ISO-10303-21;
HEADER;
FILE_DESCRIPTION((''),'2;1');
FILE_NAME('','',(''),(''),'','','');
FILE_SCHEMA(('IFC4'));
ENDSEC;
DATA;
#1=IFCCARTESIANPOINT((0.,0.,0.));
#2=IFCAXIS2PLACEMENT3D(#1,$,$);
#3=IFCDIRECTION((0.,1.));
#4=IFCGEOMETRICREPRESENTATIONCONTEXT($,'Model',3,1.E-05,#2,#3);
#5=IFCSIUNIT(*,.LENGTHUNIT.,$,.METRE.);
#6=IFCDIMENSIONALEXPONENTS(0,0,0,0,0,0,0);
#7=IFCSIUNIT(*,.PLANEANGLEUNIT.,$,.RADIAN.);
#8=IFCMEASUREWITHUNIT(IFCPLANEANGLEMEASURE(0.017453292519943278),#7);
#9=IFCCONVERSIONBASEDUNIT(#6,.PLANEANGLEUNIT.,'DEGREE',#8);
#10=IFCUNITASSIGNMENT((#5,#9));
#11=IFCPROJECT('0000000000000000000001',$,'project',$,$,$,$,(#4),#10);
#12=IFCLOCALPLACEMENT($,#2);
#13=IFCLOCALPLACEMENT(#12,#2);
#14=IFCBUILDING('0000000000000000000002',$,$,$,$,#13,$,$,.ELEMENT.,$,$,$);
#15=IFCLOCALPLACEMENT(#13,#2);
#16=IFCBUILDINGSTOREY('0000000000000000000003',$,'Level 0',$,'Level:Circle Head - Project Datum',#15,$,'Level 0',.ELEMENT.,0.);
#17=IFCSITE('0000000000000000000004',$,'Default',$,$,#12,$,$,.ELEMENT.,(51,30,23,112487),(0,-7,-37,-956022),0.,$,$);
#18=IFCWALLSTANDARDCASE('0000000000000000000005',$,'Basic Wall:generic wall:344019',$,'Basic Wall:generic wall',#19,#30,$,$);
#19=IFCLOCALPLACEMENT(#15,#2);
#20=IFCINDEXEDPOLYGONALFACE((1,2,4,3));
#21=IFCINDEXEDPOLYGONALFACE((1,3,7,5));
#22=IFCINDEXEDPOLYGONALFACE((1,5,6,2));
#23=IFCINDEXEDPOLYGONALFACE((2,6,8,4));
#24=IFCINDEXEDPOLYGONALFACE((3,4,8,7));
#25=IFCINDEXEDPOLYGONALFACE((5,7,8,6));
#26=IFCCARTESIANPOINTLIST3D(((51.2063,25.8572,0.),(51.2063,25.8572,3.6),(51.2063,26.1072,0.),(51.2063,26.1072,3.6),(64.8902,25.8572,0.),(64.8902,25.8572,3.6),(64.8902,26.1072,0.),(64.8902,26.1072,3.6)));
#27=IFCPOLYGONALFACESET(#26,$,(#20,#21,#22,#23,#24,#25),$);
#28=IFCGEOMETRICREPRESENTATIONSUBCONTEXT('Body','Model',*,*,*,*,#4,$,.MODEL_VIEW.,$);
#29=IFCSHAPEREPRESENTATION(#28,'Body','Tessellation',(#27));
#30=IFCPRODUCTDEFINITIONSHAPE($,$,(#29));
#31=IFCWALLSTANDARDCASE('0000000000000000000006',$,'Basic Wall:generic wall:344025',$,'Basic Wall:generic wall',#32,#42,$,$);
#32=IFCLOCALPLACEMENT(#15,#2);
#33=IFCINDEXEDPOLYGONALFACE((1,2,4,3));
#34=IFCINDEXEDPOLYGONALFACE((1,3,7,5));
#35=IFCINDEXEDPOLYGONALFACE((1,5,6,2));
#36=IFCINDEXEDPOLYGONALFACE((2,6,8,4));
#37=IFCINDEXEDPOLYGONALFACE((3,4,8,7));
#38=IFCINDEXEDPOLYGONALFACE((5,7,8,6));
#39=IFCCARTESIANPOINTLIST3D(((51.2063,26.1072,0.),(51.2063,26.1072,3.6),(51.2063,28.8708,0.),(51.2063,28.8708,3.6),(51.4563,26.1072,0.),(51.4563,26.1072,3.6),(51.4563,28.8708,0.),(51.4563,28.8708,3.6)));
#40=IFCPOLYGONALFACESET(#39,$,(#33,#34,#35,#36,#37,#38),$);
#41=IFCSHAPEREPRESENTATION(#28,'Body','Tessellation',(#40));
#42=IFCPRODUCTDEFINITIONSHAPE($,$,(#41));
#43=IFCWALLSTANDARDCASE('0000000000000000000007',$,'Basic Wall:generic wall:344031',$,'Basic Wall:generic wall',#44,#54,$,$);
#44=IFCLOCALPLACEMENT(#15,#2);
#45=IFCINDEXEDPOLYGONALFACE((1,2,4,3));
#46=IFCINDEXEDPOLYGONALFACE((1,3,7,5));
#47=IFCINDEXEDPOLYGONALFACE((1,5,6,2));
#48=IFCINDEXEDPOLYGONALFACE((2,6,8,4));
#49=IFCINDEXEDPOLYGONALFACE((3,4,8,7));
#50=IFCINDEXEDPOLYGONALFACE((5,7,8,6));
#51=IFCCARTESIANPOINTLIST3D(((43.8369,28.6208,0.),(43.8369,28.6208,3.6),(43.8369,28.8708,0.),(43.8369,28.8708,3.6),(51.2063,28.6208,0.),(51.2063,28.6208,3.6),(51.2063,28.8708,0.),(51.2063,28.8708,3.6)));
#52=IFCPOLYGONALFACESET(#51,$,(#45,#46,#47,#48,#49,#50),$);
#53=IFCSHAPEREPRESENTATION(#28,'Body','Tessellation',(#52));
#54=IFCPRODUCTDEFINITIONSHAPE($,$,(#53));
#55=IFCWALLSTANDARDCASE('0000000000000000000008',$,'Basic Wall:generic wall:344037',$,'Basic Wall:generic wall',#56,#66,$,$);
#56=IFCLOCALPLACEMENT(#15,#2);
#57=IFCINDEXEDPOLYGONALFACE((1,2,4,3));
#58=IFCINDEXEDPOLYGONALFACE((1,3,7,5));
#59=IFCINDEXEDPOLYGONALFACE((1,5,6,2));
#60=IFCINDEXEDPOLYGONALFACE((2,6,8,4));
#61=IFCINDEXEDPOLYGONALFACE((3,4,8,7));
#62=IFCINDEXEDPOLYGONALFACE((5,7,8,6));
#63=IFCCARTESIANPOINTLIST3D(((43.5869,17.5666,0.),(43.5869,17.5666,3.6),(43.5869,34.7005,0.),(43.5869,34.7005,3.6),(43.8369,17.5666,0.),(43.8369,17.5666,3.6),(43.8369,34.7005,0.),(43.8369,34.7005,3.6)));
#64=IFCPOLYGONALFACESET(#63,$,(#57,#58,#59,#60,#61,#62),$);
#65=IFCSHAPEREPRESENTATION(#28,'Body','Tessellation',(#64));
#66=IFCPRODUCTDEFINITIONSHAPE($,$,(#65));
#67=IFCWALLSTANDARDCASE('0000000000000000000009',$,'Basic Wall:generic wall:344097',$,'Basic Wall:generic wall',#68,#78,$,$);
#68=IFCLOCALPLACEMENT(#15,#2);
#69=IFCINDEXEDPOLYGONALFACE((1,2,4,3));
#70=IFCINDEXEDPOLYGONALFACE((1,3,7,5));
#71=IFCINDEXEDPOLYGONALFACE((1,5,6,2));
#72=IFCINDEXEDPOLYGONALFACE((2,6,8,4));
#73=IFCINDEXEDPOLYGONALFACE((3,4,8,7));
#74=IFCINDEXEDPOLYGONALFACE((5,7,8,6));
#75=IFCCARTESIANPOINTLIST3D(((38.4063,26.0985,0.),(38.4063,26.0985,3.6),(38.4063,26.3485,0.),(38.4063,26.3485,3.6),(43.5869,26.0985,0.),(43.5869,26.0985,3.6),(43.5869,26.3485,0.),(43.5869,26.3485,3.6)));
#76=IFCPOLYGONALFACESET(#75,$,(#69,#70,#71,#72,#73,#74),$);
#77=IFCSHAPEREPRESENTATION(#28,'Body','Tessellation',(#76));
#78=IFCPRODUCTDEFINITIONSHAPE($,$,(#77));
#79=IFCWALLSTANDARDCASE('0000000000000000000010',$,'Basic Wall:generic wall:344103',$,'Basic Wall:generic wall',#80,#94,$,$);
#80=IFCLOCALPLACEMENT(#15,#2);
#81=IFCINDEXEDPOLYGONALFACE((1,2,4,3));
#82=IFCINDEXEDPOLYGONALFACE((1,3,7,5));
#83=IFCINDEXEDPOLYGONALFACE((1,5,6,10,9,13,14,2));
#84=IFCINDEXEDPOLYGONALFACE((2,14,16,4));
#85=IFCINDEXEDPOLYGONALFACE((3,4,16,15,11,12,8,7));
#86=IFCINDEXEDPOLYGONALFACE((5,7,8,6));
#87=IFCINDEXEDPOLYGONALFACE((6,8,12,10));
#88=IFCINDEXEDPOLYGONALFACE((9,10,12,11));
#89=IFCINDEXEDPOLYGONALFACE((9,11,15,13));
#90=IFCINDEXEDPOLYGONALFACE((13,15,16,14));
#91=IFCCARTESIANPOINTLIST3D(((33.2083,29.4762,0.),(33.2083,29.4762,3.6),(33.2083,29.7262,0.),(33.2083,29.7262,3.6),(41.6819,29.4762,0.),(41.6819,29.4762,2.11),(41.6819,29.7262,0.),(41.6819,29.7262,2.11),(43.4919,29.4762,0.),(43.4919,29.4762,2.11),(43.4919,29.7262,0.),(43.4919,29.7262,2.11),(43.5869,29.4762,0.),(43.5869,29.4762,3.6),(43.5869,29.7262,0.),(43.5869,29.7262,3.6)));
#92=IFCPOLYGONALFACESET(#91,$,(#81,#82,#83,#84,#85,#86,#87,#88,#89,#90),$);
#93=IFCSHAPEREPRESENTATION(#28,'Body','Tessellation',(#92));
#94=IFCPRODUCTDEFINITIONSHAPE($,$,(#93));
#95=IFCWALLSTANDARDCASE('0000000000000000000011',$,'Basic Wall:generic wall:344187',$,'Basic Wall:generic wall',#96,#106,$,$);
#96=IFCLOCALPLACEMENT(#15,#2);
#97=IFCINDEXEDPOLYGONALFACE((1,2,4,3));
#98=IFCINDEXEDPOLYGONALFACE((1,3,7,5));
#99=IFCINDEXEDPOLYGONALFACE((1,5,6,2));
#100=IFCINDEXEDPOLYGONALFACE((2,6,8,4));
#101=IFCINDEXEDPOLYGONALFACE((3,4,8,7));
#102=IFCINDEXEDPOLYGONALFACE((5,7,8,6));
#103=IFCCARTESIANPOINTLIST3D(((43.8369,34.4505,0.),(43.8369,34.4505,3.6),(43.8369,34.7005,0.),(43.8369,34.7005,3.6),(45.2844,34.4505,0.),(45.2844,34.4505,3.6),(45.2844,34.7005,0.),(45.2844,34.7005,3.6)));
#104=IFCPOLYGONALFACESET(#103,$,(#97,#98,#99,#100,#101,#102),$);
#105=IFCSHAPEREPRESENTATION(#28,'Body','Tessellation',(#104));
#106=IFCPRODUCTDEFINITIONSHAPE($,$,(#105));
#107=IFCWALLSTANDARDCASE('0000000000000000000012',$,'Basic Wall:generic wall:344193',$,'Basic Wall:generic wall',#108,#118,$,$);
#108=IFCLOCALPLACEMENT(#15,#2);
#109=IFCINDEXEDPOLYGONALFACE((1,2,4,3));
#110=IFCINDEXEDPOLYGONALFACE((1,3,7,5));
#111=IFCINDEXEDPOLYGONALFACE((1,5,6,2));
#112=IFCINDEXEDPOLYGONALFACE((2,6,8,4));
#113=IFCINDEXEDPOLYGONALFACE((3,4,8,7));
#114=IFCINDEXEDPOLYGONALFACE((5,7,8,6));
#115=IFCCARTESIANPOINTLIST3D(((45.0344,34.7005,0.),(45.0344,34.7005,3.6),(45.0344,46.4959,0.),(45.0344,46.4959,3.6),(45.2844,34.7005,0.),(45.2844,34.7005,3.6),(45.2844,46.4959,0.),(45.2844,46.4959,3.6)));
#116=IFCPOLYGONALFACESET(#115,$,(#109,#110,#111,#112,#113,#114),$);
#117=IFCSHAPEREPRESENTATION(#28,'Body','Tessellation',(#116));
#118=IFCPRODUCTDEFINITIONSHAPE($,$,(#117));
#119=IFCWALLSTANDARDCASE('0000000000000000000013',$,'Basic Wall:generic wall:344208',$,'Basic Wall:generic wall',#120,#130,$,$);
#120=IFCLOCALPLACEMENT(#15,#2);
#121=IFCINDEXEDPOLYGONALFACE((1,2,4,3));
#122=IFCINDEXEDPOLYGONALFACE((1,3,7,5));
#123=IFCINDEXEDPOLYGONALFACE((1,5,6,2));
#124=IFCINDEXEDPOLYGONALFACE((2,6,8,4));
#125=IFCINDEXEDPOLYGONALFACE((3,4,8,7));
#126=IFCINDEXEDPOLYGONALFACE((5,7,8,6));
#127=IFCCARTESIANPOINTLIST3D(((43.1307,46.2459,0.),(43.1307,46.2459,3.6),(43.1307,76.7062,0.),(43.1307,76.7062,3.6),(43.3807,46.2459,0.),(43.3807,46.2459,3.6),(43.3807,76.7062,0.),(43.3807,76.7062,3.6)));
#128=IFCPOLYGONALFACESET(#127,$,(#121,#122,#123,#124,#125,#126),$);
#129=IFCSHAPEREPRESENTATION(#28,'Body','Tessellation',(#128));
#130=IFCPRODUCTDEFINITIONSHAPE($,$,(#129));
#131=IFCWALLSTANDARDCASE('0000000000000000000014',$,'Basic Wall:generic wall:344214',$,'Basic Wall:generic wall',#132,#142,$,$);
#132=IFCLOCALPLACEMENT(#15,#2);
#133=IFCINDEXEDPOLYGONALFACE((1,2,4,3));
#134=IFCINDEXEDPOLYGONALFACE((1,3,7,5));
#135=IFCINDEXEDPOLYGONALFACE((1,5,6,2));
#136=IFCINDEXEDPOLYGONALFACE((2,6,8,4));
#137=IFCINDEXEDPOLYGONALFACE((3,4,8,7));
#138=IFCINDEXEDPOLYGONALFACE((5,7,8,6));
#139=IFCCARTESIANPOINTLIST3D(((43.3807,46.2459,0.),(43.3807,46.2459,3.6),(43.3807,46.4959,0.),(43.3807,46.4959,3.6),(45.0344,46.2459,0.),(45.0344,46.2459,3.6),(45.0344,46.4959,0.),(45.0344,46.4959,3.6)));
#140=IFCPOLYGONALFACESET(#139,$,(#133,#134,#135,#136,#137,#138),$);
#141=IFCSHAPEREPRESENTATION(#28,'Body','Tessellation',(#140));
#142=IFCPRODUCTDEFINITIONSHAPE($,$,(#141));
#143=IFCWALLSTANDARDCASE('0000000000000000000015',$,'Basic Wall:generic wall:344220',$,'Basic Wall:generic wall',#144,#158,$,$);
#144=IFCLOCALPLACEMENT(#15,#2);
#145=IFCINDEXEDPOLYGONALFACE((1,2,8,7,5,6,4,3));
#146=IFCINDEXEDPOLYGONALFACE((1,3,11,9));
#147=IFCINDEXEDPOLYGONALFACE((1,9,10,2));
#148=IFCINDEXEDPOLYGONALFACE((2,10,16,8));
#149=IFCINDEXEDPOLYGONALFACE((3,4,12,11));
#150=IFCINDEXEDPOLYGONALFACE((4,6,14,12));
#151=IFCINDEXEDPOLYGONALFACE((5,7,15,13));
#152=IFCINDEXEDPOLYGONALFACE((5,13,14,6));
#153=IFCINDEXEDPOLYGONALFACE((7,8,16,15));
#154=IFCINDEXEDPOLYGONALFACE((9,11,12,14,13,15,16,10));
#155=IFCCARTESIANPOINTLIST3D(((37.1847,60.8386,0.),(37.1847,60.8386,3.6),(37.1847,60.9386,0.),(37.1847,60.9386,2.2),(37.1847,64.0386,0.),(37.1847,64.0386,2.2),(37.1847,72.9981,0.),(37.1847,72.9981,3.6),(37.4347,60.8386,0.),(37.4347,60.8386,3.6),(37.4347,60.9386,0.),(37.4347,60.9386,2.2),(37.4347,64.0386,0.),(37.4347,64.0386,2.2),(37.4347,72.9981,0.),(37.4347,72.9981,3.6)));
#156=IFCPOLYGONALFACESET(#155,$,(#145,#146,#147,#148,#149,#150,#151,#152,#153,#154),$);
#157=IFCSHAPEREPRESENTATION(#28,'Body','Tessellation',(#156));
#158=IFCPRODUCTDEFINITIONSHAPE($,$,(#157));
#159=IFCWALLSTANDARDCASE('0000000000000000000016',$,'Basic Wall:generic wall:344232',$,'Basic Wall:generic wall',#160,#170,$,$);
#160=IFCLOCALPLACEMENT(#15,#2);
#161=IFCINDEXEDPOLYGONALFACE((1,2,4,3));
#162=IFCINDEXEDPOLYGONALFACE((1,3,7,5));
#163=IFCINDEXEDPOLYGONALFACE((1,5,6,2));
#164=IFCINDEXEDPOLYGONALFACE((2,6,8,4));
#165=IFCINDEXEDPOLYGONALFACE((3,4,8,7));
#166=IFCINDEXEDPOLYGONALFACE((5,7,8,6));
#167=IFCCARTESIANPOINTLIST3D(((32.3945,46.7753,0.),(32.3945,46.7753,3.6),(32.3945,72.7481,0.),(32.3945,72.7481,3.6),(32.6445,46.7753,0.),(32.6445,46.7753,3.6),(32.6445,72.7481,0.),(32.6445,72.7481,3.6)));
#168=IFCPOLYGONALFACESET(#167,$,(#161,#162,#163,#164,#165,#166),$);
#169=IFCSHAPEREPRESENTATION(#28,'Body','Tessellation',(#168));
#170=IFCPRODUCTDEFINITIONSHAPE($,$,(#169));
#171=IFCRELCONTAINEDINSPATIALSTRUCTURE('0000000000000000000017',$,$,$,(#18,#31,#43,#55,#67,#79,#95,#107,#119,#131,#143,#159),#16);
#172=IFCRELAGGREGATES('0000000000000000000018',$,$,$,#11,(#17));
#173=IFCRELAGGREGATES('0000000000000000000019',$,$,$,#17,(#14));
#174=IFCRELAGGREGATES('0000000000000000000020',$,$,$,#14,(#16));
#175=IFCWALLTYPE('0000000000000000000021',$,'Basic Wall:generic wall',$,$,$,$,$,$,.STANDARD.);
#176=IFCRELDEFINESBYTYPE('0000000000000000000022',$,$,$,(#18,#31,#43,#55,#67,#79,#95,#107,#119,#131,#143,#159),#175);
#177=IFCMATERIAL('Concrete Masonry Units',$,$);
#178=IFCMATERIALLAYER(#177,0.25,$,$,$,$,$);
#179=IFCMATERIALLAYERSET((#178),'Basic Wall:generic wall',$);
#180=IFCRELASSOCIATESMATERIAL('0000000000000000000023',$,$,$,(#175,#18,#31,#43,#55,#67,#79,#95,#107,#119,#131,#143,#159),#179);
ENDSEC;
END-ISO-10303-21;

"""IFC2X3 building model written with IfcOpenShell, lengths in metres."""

from ifc_helpers import new_model, entity, si_unit, converted_unit, direction, frame, frame_2d, origin, place, context, subcontext, project, spatial, rectangle, extrude, material, layer, layer_set, layer_usage, type_object, element, save


model = new_model("IFC2X3")

# Units and contexts
model_context = context("Model", 3, precision=1e-05, world=origin(), true_north=direction((0.0, 1.0)))
body_context = subcontext(model_context, "Body", "Model", "MODEL_VIEW")
ifc_project = project(units=[si_unit("LENGTHUNIT", "METRE"), converted_unit("PLANEANGLEUNIT", "DEGREE", entity("IfcPlaneAngleMeasure", 0.017453292519943278), si_unit("PLANEANGLEUNIT", "RADIAN"), dimensions=[0, 0, 0, 0, 0, 0, 0])], contexts=[model_context])

# Site, building, storey
site_placement = place(None, origin())
site = spatial("IfcSite", under=ifc_project, at=site_placement, Name="Default", CompositionType="ELEMENT", RefLatitude=(51, 30, 23, 112487), RefLongitude=(0, -7, -37, -956022), RefElevation=0.0)
building_placement = place(site_placement, origin())
building = spatial("IfcBuilding", under=site, at=building_placement, CompositionType="ELEMENT")
storey_placement = place(building_placement, origin())
storey = spatial("IfcBuildingStorey", under=building, at=storey_placement, Name="Level 0", ObjectType="Level:Circle Head - Project Datum", LongName="Level 0", CompositionType="ELEMENT", Elevation=0.0)

# Walls
ifc_material = material(Name="Concrete Masonry Units")
ifc_layer = layer(ifc_material, 0.25)
ifc_layer_set = layer_set([ifc_layer], Name="Basic Wall:generic wall")
ifc_layer_usage_1 = layer_usage(ifc_layer_set, "AXIS2", "NEGATIVE", 0.125)
wall_type = type_object("IfcWallType", Name="Basic Wall:generic wall", PredefinedType="STANDARD", material=ifc_layer_set)
wall_1_placement = place(storey_placement, frame((64.8902, 25.9822, 0.0), z_axis=(0.0, 0.0, 1.0), x_axis=(-1.0, 0.0, 0.0)))
element("IfcWallStandardCase", 1, at=wall_1_placement, inside=storey, type_object=wall_type, material=ifc_layer_usage_1, Name="Basic Wall:generic wall:344019", ObjectType="Basic Wall:generic wall", context=body_context, shape_type="SweptSolid", body=[
    extrude(rectangle(XDim=13.6839, YDim=0.25, at=frame_2d((6.8419, 0.0), x_axis=(-1.0, 0.0))), origin(), (0.0, 0.0, 1.0), 3.6),
])
ifc_layer_usage_2 = layer_usage(ifc_layer_set, "AXIS2", "NEGATIVE", 0.125)
wall_2_placement = place(storey_placement, frame((51.3313, 26.1072, 0.0), z_axis=(0.0, 0.0, 1.0), x_axis=(0.0, 1.0, 0.0)))
element("IfcWallStandardCase", 2, at=wall_2_placement, inside=storey, type_object=wall_type, material=ifc_layer_usage_2, Name="Basic Wall:generic wall:344025", ObjectType="Basic Wall:generic wall", context=body_context, shape_type="SweptSolid", body=[
    extrude(rectangle(XDim=2.7635, YDim=0.25, at=frame_2d((1.3818, 0.0), x_axis=(-1.0, 0.0))), origin(), (0.0, 0.0, 1.0), 3.6),
])
ifc_layer_usage_3 = layer_usage(ifc_layer_set, "AXIS2", "NEGATIVE", 0.125)
wall_3_placement = place(storey_placement, frame((51.2063, 28.7458, 0.0), z_axis=(0.0, 0.0, 1.0), x_axis=(-1.0, 0.0, 0.0)))
element("IfcWallStandardCase", 3, at=wall_3_placement, inside=storey, type_object=wall_type, material=ifc_layer_usage_3, Name="Basic Wall:generic wall:344031", ObjectType="Basic Wall:generic wall", context=body_context, shape_type="SweptSolid", body=[
    extrude(rectangle(XDim=7.3694, YDim=0.25, at=frame_2d((3.6847, 0.0), x_axis=(-1.0, 0.0))), origin(), (0.0, 0.0, 1.0), 3.6),
])
ifc_layer_usage_4 = layer_usage(ifc_layer_set, "AXIS2", "NEGATIVE", 0.125)
wall_4_placement = place(storey_placement, frame((43.7119, 34.7005, 0.0), z_axis=(0.0, 0.0, 1.0), x_axis=(0.0, -1.0, 0.0)))
element("IfcWallStandardCase", 4, at=wall_4_placement, inside=storey, type_object=wall_type, material=ifc_layer_usage_4, Name="Basic Wall:generic wall:344037", ObjectType="Basic Wall:generic wall", context=body_context, shape_type="SweptSolid", body=[
    extrude(rectangle(XDim=17.1339, YDim=0.25, at=frame_2d((8.5669, 0.0), x_axis=(-1.0, 0.0))), origin(), (0.0, 0.0, 1.0), 3.6),
])
ifc_layer_usage_5 = layer_usage(ifc_layer_set, "AXIS2", "NEGATIVE", 0.125)
wall_5_placement = place(storey_placement, frame((38.4063, 26.2235, 0.0)))
element("IfcWallStandardCase", 5, at=wall_5_placement, inside=storey, type_object=wall_type, material=ifc_layer_usage_5, Name="Basic Wall:generic wall:344097", ObjectType="Basic Wall:generic wall", context=body_context, shape_type="SweptSolid", body=[
    extrude(rectangle(XDim=5.1806, YDim=0.25, at=frame_2d((2.5903, 0.0), x_axis=(-1.0, 0.0))), origin(), (0.0, 0.0, 1.0), 3.6),
])

# Wall, opening
ifc_layer_usage_6 = layer_usage(ifc_layer_set, "AXIS2", "NEGATIVE", 0.125)
wall_6_placement = place(storey_placement, frame((33.2083, 29.6012, 0.0)))
wall_6 = element("IfcWallStandardCase", 6, at=wall_6_placement, inside=storey, type_object=wall_type, material=ifc_layer_usage_6, Name="Basic Wall:generic wall:344103", ObjectType="Basic Wall:generic wall", context=body_context, shape_type="SweptSolid", body=[
    extrude(rectangle(XDim=10.3786, YDim=0.25, at=frame_2d((5.1893, 0.0), x_axis=(-1.0, 0.0))), origin(), (0.0, 0.0, 1.0), 3.6),
])
opening_1_placement = place(wall_6_placement, frame((10.2836, 0.125, 0.0)))
element("IfcOpeningElement", 7, at=opening_1_placement, cuts=wall_6, ObjectType="Opening", context=body_context, shape_type="SweptSolid", body=[
    extrude(rectangle(XDim=2.11, YDim=1.81, at=frame_2d((1.055, 0.905), x_axis=(-1.0, 0.0))), frame((0.0, 0.0, 0.0), z_axis=(0.0, -1.0, 0.0), x_axis=(0.0, 0.0, 1.0)), (0.0, 0.0, 1.0), 0.25),
])

# Walls
ifc_layer_usage_7 = layer_usage(ifc_layer_set, "AXIS2", "NEGATIVE", 0.125)
wall_7_placement = place(storey_placement, frame((43.8369, 34.5755, 0.0)))
element("IfcWallStandardCase", 8, at=wall_7_placement, inside=storey, type_object=wall_type, material=ifc_layer_usage_7, Name="Basic Wall:generic wall:344187", ObjectType="Basic Wall:generic wall", context=body_context, shape_type="SweptSolid", body=[
    extrude(rectangle(XDim=1.4475, YDim=0.25, at=frame_2d((0.7238, 0.0), x_axis=(-1.0, 0.0))), origin(), (0.0, 0.0, 1.0), 3.6),
])
ifc_layer_usage_8 = layer_usage(ifc_layer_set, "AXIS2", "NEGATIVE", 0.125)
wall_8_placement = place(storey_placement, frame((45.1594, 34.7005, 0.0), z_axis=(0.0, 0.0, 1.0), x_axis=(0.0, 1.0, 0.0)))
element("IfcWallStandardCase", 9, at=wall_8_placement, inside=storey, type_object=wall_type, material=ifc_layer_usage_8, Name="Basic Wall:generic wall:344193", ObjectType="Basic Wall:generic wall", context=body_context, shape_type="SweptSolid", body=[
    extrude(rectangle(XDim=11.7954, YDim=0.25, at=frame_2d((5.8977, 0.0), x_axis=(-1.0, 0.0))), origin(), (0.0, 0.0, 1.0), 3.6),
])
ifc_layer_usage_9 = layer_usage(ifc_layer_set, "AXIS2", "NEGATIVE", 0.125)
wall_9_placement = place(storey_placement, frame((43.2557, 46.2459, 0.0), z_axis=(0.0, 0.0, 1.0), x_axis=(0.0, 1.0, 0.0)))
element("IfcWallStandardCase", 10, at=wall_9_placement, inside=storey, type_object=wall_type, material=ifc_layer_usage_9, Name="Basic Wall:generic wall:344208", ObjectType="Basic Wall:generic wall", context=body_context, shape_type="SweptSolid", body=[
    extrude(rectangle(XDim=30.4602, YDim=0.25, at=frame_2d((15.2301, 0.0), x_axis=(-1.0, 0.0))), origin(), (0.0, 0.0, 1.0), 3.6),
])
ifc_layer_usage_10 = layer_usage(ifc_layer_set, "AXIS2", "NEGATIVE", 0.125)
wall_10_placement = place(storey_placement, frame((45.0344, 46.3709, 0.0), z_axis=(0.0, 0.0, 1.0), x_axis=(-1.0, 0.0, 0.0)))
element("IfcWallStandardCase", 11, at=wall_10_placement, inside=storey, type_object=wall_type, material=ifc_layer_usage_10, Name="Basic Wall:generic wall:344214", ObjectType="Basic Wall:generic wall", context=body_context, shape_type="SweptSolid", body=[
    extrude(rectangle(XDim=1.6538, YDim=0.25, at=frame_2d((0.8269, 0.0), x_axis=(-1.0, 0.0))), origin(), (0.0, 0.0, 1.0), 3.6),
])

# Wall, opening
ifc_layer_usage_11 = layer_usage(ifc_layer_set, "AXIS2", "NEGATIVE", 0.125)
wall_11_placement = place(storey_placement, frame((37.3097, 72.9981, 0.0), z_axis=(0.0, 0.0, 1.0), x_axis=(0.0, -1.0, 0.0)))
wall_11 = element("IfcWallStandardCase", 12, at=wall_11_placement, inside=storey, type_object=wall_type, material=ifc_layer_usage_11, Name="Basic Wall:generic wall:344220", ObjectType="Basic Wall:generic wall", context=body_context, shape_type="SweptSolid", body=[
    extrude(rectangle(XDim=12.1595, YDim=0.25, at=frame_2d((6.0798, 0.0), x_axis=(-1.0, 0.0))), origin(), (0.0, 0.0, 1.0), 3.6),
])
opening_2_placement = place(wall_11_placement, frame((12.0595, 0.125, 0.0)))
element("IfcOpeningElement", 13, at=opening_2_placement, cuts=wall_11, ObjectType="Opening", context=body_context, shape_type="SweptSolid", body=[
    extrude(rectangle(XDim=2.2, YDim=3.1, at=frame_2d((1.1, 1.55), x_axis=(1.0, 0.0))), frame((0.0, 0.0, 0.0), z_axis=(0.0, -1.0, 0.0), x_axis=(0.0, 0.0, 1.0)), (0.0, 0.0, 1.0), 0.25),
])

# Wall
ifc_layer_usage_12 = layer_usage(ifc_layer_set, "AXIS2", "NEGATIVE", 0.125)
wall_12_placement = place(storey_placement, frame((32.5195, 72.7481, 0.0), z_axis=(0.0, 0.0, 1.0), x_axis=(0.0, -1.0, 0.0)))
element("IfcWallStandardCase", 14, at=wall_12_placement, inside=storey, type_object=wall_type, material=ifc_layer_usage_12, Name="Basic Wall:generic wall:344232", ObjectType="Basic Wall:generic wall", context=body_context, shape_type="SweptSolid", body=[
    extrude(rectangle(XDim=25.9728, YDim=0.25, at=frame_2d((12.9864, 0.0), x_axis=(-1.0, 0.0))), origin(), (0.0, 0.0, 1.0), 3.6),
])

save(model, "model.ifc")
